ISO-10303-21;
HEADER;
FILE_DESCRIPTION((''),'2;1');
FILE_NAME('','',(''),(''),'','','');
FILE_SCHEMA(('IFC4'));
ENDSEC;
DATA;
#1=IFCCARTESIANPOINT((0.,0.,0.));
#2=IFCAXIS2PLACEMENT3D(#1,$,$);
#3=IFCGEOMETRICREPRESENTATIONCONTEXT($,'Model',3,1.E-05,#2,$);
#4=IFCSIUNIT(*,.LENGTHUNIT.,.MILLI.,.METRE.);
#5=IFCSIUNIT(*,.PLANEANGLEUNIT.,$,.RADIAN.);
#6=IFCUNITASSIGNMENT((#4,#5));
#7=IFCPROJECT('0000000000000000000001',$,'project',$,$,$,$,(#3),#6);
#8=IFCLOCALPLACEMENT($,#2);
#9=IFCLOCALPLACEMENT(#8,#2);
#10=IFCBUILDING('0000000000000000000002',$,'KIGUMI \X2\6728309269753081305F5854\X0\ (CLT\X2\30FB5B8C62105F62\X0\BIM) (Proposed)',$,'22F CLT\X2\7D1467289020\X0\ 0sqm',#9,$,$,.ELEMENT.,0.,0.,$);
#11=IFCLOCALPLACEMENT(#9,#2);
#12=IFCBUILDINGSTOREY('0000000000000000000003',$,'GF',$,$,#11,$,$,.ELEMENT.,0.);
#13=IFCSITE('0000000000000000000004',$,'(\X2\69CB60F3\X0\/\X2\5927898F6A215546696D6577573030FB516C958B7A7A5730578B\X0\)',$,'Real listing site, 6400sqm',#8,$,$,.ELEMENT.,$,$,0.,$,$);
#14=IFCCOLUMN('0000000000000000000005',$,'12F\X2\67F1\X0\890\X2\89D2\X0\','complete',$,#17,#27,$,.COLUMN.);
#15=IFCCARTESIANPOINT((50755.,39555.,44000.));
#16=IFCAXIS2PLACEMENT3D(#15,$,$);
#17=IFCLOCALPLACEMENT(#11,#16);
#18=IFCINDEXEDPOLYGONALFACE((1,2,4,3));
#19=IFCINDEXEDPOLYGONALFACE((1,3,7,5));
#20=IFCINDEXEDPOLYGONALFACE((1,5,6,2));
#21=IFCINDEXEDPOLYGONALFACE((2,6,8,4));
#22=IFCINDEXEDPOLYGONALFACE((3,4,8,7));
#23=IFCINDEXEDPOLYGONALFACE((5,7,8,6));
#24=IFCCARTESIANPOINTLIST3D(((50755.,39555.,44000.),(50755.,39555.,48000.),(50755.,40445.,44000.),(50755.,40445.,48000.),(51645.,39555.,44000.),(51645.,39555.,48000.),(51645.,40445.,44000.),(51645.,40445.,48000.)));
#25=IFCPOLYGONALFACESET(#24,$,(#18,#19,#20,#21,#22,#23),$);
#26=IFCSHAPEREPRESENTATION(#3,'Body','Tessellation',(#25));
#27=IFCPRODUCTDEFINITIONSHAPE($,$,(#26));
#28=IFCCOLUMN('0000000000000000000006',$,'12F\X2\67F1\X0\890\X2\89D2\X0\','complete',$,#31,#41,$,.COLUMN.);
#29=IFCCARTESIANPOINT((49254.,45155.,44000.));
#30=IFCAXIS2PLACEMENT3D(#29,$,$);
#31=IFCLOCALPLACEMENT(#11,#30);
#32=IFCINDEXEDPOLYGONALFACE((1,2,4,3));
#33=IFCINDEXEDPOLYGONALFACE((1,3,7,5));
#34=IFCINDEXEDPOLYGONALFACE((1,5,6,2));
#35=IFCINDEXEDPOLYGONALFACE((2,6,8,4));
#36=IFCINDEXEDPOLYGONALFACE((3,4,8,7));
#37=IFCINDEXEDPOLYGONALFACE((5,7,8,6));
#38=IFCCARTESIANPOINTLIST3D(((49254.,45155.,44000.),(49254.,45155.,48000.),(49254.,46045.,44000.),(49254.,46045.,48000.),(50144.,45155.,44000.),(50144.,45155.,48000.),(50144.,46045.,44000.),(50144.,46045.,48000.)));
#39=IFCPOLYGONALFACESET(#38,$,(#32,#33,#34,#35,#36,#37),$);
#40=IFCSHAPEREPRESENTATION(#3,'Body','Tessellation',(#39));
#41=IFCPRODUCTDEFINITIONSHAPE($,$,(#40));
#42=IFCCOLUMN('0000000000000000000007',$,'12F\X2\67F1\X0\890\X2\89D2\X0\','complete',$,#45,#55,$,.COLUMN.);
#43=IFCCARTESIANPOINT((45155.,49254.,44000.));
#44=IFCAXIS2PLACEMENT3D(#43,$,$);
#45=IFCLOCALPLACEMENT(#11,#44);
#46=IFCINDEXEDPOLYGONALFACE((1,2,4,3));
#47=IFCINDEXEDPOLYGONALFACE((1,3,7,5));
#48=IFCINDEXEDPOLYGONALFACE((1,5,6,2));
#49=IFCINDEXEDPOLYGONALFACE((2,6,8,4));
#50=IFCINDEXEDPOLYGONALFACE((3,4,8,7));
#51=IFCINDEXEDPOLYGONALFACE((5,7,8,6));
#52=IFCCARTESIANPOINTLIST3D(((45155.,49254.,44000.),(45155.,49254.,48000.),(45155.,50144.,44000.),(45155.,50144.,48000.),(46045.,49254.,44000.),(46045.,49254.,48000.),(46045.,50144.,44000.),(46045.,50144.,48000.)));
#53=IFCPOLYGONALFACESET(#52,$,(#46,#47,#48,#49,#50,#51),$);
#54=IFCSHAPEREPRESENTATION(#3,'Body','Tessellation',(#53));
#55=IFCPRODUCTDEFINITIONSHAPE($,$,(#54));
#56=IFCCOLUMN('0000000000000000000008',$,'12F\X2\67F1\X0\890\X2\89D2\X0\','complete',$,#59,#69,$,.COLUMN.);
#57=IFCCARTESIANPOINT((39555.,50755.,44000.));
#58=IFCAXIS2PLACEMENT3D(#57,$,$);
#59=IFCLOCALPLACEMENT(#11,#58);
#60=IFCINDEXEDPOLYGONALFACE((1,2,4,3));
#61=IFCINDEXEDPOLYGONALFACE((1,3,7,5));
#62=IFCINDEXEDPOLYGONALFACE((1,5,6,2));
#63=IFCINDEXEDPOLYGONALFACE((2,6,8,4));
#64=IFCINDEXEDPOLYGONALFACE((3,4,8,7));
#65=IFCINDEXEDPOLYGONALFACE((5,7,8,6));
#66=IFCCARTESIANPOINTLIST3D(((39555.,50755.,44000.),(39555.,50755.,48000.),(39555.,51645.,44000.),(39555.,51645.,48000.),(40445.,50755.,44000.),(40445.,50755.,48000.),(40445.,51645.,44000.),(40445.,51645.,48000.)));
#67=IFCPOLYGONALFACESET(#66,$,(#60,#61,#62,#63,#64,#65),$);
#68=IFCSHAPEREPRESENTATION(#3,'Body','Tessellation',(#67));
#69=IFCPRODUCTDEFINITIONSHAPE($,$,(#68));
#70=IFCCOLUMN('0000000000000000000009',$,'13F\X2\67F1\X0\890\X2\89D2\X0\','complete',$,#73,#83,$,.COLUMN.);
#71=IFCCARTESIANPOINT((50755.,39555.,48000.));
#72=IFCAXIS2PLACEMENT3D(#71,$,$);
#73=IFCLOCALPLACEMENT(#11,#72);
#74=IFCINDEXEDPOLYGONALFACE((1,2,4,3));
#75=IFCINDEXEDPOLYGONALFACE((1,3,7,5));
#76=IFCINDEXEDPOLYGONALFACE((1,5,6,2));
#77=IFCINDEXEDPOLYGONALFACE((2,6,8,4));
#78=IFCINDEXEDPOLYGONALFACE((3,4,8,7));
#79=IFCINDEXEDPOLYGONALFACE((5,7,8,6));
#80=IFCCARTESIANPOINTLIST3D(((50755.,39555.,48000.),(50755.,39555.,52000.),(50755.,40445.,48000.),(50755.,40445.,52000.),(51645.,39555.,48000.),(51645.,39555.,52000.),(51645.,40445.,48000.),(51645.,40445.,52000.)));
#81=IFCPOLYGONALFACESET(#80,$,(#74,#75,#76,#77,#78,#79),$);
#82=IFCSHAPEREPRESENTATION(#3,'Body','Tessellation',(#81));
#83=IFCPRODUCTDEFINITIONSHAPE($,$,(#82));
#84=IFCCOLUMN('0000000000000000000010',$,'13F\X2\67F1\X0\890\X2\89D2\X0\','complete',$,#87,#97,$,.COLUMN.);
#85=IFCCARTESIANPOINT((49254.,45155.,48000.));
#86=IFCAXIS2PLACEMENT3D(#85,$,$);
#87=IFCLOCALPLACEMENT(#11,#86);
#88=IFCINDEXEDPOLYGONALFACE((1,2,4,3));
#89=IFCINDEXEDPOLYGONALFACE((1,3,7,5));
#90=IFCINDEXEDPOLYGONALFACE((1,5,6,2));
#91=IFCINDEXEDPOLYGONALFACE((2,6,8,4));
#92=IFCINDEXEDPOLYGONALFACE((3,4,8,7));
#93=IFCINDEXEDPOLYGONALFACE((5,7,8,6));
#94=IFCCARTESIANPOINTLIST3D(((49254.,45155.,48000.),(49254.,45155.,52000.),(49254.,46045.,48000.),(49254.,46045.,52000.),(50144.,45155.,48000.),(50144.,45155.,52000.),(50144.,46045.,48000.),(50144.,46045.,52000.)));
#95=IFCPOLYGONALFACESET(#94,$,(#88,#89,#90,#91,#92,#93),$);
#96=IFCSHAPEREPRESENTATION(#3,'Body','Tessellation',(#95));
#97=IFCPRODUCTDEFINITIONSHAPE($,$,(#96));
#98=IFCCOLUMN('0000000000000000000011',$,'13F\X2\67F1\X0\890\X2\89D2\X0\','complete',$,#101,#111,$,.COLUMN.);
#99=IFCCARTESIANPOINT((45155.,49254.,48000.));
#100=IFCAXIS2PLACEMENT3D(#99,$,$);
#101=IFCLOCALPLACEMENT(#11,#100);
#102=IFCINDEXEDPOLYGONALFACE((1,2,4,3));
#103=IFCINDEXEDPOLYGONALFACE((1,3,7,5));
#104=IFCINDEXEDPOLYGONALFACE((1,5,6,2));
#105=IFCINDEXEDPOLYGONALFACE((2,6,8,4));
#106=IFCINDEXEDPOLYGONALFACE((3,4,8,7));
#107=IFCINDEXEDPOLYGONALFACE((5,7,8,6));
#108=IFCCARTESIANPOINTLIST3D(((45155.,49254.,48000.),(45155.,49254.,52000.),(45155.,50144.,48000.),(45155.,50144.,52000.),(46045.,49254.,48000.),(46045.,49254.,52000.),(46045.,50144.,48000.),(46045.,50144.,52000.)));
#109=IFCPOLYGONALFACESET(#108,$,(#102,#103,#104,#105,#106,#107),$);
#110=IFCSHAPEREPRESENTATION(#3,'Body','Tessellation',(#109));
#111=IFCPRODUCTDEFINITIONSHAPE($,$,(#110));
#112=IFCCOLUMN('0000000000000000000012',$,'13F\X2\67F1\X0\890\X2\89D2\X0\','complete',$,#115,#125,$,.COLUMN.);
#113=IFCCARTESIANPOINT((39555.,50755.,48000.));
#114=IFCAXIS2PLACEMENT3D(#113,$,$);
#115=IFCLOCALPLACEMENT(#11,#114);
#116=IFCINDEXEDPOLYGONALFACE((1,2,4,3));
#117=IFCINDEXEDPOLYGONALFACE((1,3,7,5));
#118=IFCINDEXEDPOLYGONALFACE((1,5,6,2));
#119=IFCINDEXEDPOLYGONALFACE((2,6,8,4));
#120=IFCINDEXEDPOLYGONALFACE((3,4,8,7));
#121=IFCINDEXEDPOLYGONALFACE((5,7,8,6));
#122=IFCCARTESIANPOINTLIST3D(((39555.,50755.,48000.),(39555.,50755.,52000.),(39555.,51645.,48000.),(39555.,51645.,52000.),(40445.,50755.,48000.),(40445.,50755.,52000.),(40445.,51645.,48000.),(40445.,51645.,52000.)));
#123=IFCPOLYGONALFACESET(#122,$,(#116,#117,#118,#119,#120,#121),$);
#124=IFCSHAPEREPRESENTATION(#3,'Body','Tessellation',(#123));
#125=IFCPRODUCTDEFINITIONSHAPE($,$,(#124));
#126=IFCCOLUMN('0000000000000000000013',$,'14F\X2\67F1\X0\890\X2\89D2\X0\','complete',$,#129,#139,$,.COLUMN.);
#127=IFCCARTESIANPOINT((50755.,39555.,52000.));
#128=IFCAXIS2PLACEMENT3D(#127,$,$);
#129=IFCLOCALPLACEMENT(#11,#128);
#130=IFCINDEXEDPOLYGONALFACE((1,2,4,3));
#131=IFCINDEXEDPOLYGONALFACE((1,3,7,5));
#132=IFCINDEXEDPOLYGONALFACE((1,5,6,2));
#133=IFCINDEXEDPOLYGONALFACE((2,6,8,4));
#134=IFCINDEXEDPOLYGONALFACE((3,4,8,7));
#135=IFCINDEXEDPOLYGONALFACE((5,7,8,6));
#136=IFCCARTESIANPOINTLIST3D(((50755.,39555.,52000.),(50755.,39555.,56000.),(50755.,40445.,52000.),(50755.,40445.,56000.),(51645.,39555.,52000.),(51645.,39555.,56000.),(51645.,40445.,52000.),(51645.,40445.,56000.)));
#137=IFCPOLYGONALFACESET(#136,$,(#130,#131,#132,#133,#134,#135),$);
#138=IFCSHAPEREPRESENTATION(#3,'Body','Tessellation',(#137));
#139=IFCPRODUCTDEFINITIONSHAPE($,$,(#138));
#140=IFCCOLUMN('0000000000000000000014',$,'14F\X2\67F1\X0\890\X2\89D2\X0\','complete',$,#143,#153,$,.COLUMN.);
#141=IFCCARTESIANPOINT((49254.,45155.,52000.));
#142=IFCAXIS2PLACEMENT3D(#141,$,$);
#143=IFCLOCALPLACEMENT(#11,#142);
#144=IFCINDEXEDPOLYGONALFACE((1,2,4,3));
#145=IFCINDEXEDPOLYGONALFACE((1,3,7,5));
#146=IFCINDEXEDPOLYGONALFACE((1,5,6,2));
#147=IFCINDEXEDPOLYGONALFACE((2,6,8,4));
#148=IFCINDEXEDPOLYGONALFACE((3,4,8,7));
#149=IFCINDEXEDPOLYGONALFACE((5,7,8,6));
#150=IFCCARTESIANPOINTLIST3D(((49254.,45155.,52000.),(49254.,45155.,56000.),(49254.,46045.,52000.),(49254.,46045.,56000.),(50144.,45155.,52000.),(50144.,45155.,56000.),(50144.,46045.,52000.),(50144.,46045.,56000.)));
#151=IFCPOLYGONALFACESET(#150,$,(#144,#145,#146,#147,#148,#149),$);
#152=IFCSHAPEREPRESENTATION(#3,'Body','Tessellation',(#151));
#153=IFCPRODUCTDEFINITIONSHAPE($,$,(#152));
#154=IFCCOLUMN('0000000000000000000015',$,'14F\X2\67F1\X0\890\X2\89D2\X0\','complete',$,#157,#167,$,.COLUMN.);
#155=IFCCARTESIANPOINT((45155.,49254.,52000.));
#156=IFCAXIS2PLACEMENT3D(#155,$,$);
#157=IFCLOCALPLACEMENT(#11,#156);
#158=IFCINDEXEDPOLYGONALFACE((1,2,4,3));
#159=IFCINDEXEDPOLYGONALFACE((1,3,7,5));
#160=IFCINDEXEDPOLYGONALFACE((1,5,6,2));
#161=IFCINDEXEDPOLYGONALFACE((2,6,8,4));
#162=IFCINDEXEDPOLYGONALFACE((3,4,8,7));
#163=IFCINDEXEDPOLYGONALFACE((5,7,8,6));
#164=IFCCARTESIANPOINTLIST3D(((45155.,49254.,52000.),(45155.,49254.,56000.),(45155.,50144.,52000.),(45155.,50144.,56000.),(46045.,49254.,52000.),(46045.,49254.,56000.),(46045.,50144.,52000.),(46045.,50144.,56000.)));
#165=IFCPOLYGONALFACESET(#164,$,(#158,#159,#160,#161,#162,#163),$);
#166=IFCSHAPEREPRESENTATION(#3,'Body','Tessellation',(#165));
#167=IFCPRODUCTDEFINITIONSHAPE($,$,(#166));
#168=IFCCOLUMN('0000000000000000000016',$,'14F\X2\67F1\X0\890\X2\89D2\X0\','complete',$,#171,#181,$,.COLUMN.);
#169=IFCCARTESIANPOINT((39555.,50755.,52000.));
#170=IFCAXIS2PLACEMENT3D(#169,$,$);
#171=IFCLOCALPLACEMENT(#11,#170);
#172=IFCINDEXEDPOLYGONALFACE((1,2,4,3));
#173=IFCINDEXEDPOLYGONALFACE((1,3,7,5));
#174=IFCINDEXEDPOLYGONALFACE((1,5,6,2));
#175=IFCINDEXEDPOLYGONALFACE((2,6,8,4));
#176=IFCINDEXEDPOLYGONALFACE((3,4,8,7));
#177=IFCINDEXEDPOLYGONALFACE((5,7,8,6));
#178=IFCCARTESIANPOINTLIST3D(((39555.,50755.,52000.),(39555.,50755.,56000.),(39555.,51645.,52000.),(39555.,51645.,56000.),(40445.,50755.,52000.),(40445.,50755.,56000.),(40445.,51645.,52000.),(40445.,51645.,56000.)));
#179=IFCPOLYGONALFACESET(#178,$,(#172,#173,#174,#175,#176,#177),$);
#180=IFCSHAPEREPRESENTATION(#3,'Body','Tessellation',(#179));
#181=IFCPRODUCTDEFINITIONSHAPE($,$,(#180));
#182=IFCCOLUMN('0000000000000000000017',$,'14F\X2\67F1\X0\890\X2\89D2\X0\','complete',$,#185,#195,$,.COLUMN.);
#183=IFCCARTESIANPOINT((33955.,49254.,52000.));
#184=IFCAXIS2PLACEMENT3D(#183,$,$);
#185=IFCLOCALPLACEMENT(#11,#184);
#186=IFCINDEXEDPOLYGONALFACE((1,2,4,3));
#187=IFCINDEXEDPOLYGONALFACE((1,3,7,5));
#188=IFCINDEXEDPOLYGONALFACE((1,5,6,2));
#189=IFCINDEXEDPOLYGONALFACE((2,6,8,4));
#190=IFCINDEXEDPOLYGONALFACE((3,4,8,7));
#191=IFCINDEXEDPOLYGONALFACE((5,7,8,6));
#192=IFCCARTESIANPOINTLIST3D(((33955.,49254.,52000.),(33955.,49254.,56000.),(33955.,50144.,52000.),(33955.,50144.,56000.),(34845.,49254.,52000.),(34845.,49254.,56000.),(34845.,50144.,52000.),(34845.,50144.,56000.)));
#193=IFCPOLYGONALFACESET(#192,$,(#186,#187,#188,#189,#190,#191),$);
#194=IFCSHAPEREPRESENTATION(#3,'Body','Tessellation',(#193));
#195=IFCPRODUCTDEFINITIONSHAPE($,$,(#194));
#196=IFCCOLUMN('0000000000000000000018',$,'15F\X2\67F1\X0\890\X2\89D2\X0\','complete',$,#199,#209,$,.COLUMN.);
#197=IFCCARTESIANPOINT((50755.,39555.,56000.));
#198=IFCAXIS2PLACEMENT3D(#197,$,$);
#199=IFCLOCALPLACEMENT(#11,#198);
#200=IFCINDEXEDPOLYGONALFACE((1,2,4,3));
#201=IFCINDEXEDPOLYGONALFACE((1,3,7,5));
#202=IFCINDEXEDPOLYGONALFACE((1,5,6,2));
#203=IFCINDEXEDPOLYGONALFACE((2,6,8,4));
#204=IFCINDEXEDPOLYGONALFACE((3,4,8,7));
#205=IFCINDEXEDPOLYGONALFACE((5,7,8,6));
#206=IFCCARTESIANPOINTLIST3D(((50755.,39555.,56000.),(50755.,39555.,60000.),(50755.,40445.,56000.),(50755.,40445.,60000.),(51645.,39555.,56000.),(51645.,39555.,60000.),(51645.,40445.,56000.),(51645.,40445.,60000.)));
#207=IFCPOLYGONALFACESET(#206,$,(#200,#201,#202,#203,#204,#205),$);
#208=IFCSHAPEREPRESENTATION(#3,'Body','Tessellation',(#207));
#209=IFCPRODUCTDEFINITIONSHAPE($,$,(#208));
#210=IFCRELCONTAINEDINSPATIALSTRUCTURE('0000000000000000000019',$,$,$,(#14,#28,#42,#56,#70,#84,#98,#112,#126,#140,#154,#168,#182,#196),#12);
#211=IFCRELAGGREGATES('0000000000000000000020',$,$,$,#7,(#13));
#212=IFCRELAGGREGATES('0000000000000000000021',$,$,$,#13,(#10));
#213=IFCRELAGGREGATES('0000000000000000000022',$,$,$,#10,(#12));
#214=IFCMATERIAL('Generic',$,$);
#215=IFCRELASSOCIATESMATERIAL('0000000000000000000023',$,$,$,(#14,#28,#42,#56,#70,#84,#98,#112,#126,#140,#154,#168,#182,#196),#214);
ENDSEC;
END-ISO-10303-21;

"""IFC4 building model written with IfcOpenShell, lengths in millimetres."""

from ifc_helpers import new_model, si_unit, frame, frame_2d, origin, place, context, project, spatial, rectangle, extrude, material, element, save


model = new_model("IFC4")

# Units and contexts
model_context = context("Model", 3, precision=1e-05, world=origin())
ifc_project = project(units=[si_unit("LENGTHUNIT", "METRE", prefix="MILLI"), si_unit("PLANEANGLEUNIT", "RADIAN")], contexts=[model_context])

# Site, building, storey
site_placement = place(None, origin())
site = spatial("IfcSite", under=ifc_project, at=site_placement, Name="(構想/大規模商業敷地・公開空地型)", ObjectType="Real listing site, 6400sqm", CompositionType="ELEMENT", RefElevation=0.0)
building_placement = place(site_placement, origin())
building = spatial("IfcBuilding", under=site, at=building_placement, Name="KIGUMI 木を極めた塔 (CLT・完成形BIM) (Proposed)", ObjectType="22F CLT純木造 0sqm", CompositionType="ELEMENT", ElevationOfRefHeight=0.0, ElevationOfTerrain=0.0)
storey_placement = place(building_placement, origin())
storey = spatial("IfcBuildingStorey", under=building, at=storey_placement, Name="GF", CompositionType="ELEMENT", Elevation=0.0)

# Columns
ifc_material = material(Name="Generic")
column_1_placement = place(storey_placement, frame((50755.0, 39555.0, 44000.0)))
element("IfcColumn", 1, at=column_1_placement, inside=storey, material=ifc_material, Name="12F柱890角", Description="complete", PredefinedType="COLUMN", context=model_context, shape_type="SweptSolid", body=[
    extrude(rectangle(XDim=890.0, YDim=890.0, at=frame_2d((445.0, 445.0))), frame((50755.0, 39555.0, 44000.0)), (0.0, 0.0, 1.0), 4000.0),
])
column_2_placement = place(storey_placement, frame((49254.0, 45155.0, 44000.0)))
element("IfcColumn", 2, at=column_2_placement, inside=storey, material=ifc_material, Name="12F柱890角", Description="complete", PredefinedType="COLUMN", context=model_context, shape_type="SweptSolid", body=[
    extrude(rectangle(XDim=890.0, YDim=890.0, at=frame_2d((445.0, 445.0))), frame((49254.0, 45155.0, 44000.0)), (0.0, 0.0, 1.0), 4000.0),
])
column_3_placement = place(storey_placement, frame((45155.0, 49254.0, 44000.0)))
element("IfcColumn", 3, at=column_3_placement, inside=storey, material=ifc_material, Name="12F柱890角", Description="complete", PredefinedType="COLUMN", context=model_context, shape_type="SweptSolid", body=[
    extrude(rectangle(XDim=890.0, YDim=890.0, at=frame_2d((445.0, 445.0))), frame((45155.0, 49254.0, 44000.0)), (0.0, 0.0, 1.0), 4000.0),
])
column_4_placement = place(storey_placement, frame((39555.0, 50755.0, 44000.0)))
element("IfcColumn", 4, at=column_4_placement, inside=storey, material=ifc_material, Name="12F柱890角", Description="complete", PredefinedType="COLUMN", context=model_context, shape_type="SweptSolid", body=[
    extrude(rectangle(XDim=890.0, YDim=890.0, at=frame_2d((445.0, 445.0))), frame((39555.0, 50755.0, 44000.0)), (0.0, 0.0, 1.0), 4000.0),
])
column_5_placement = place(storey_placement, frame((50755.0, 39555.0, 48000.0)))
element("IfcColumn", 5, at=column_5_placement, inside=storey, material=ifc_material, Name="13F柱890角", Description="complete", PredefinedType="COLUMN", context=model_context, shape_type="SweptSolid", body=[
    extrude(rectangle(XDim=890.0, YDim=890.0, at=frame_2d((445.0, 445.0))), frame((50755.0, 39555.0, 48000.0)), (0.0, 0.0, 1.0), 4000.0),
])
column_6_placement = place(storey_placement, frame((49254.0, 45155.0, 48000.0)))
element("IfcColumn", 6, at=column_6_placement, inside=storey, material=ifc_material, Name="13F柱890角", Description="complete", PredefinedType="COLUMN", context=model_context, shape_type="SweptSolid", body=[
    extrude(rectangle(XDim=890.0, YDim=890.0, at=frame_2d((445.0, 445.0))), frame((49254.0, 45155.0, 48000.0)), (0.0, 0.0, 1.0), 4000.0),
])
column_7_placement = place(storey_placement, frame((45155.0, 49254.0, 48000.0)))
element("IfcColumn", 7, at=column_7_placement, inside=storey, material=ifc_material, Name="13F柱890角", Description="complete", PredefinedType="COLUMN", context=model_context, shape_type="SweptSolid", body=[
    extrude(rectangle(XDim=890.0, YDim=890.0, at=frame_2d((445.0, 445.0))), frame((45155.0, 49254.0, 48000.0)), (0.0, 0.0, 1.0), 4000.0),
])
column_8_placement = place(storey_placement, frame((39555.0, 50755.0, 48000.0)))
element("IfcColumn", 8, at=column_8_placement, inside=storey, material=ifc_material, Name="13F柱890角", Description="complete", PredefinedType="COLUMN", context=model_context, shape_type="SweptSolid", body=[
    extrude(rectangle(XDim=890.0, YDim=890.0, at=frame_2d((445.0, 445.0))), frame((39555.0, 50755.0, 48000.0)), (0.0, 0.0, 1.0), 4000.0),
])
column_9_placement = place(storey_placement, frame((50755.0, 39555.0, 52000.0)))
element("IfcColumn", 9, at=column_9_placement, inside=storey, material=ifc_material, Name="14F柱890角", Description="complete", PredefinedType="COLUMN", context=model_context, shape_type="SweptSolid", body=[
    extrude(rectangle(XDim=890.0, YDim=890.0, at=frame_2d((445.0, 445.0))), frame((50755.0, 39555.0, 52000.0)), (0.0, 0.0, 1.0), 4000.0),
])
column_10_placement = place(storey_placement, frame((49254.0, 45155.0, 52000.0)))
element("IfcColumn", 10, at=column_10_placement, inside=storey, material=ifc_material, Name="14F柱890角", Description="complete", PredefinedType="COLUMN", context=model_context, shape_type="SweptSolid", body=[
    extrude(rectangle(XDim=890.0, YDim=890.0, at=frame_2d((445.0, 445.0))), frame((49254.0, 45155.0, 52000.0)), (0.0, 0.0, 1.0), 4000.0),
])
column_11_placement = place(storey_placement, frame((45155.0, 49254.0, 52000.0)))
element("IfcColumn", 11, at=column_11_placement, inside=storey, material=ifc_material, Name="14F柱890角", Description="complete", PredefinedType="COLUMN", context=model_context, shape_type="SweptSolid", body=[
    extrude(rectangle(XDim=890.0, YDim=890.0, at=frame_2d((445.0, 445.0))), frame((45155.0, 49254.0, 52000.0)), (0.0, 0.0, 1.0), 4000.0),
])
column_12_placement = place(storey_placement, frame((39555.0, 50755.0, 52000.0)))
element("IfcColumn", 12, at=column_12_placement, inside=storey, material=ifc_material, Name="14F柱890角", Description="complete", PredefinedType="COLUMN", context=model_context, shape_type="SweptSolid", body=[
    extrude(rectangle(XDim=890.0, YDim=890.0, at=frame_2d((445.0, 445.0))), frame((39555.0, 50755.0, 52000.0)), (0.0, 0.0, 1.0), 4000.0),
])
column_13_placement = place(storey_placement, frame((33955.0, 49254.0, 52000.0)))
element("IfcColumn", 13, at=column_13_placement, inside=storey, material=ifc_material, Name="14F柱890角", Description="complete", PredefinedType="COLUMN", context=model_context, shape_type="SweptSolid", body=[
    extrude(rectangle(XDim=890.0, YDim=890.0, at=frame_2d((445.0, 445.0))), frame((33955.0, 49254.0, 52000.0)), (0.0, 0.0, 1.0), 4000.0),
])
column_14_placement = place(storey_placement, frame((50755.0, 39555.0, 56000.0)))
element("IfcColumn", 14, at=column_14_placement, inside=storey, material=ifc_material, Name="15F柱890角", Description="complete", PredefinedType="COLUMN", context=model_context, shape_type="SweptSolid", body=[
    extrude(rectangle(XDim=890.0, YDim=890.0, at=frame_2d((445.0, 445.0))), frame((50755.0, 39555.0, 56000.0)), (0.0, 0.0, 1.0), 4000.0),
])

save(model, "model.ifc")
